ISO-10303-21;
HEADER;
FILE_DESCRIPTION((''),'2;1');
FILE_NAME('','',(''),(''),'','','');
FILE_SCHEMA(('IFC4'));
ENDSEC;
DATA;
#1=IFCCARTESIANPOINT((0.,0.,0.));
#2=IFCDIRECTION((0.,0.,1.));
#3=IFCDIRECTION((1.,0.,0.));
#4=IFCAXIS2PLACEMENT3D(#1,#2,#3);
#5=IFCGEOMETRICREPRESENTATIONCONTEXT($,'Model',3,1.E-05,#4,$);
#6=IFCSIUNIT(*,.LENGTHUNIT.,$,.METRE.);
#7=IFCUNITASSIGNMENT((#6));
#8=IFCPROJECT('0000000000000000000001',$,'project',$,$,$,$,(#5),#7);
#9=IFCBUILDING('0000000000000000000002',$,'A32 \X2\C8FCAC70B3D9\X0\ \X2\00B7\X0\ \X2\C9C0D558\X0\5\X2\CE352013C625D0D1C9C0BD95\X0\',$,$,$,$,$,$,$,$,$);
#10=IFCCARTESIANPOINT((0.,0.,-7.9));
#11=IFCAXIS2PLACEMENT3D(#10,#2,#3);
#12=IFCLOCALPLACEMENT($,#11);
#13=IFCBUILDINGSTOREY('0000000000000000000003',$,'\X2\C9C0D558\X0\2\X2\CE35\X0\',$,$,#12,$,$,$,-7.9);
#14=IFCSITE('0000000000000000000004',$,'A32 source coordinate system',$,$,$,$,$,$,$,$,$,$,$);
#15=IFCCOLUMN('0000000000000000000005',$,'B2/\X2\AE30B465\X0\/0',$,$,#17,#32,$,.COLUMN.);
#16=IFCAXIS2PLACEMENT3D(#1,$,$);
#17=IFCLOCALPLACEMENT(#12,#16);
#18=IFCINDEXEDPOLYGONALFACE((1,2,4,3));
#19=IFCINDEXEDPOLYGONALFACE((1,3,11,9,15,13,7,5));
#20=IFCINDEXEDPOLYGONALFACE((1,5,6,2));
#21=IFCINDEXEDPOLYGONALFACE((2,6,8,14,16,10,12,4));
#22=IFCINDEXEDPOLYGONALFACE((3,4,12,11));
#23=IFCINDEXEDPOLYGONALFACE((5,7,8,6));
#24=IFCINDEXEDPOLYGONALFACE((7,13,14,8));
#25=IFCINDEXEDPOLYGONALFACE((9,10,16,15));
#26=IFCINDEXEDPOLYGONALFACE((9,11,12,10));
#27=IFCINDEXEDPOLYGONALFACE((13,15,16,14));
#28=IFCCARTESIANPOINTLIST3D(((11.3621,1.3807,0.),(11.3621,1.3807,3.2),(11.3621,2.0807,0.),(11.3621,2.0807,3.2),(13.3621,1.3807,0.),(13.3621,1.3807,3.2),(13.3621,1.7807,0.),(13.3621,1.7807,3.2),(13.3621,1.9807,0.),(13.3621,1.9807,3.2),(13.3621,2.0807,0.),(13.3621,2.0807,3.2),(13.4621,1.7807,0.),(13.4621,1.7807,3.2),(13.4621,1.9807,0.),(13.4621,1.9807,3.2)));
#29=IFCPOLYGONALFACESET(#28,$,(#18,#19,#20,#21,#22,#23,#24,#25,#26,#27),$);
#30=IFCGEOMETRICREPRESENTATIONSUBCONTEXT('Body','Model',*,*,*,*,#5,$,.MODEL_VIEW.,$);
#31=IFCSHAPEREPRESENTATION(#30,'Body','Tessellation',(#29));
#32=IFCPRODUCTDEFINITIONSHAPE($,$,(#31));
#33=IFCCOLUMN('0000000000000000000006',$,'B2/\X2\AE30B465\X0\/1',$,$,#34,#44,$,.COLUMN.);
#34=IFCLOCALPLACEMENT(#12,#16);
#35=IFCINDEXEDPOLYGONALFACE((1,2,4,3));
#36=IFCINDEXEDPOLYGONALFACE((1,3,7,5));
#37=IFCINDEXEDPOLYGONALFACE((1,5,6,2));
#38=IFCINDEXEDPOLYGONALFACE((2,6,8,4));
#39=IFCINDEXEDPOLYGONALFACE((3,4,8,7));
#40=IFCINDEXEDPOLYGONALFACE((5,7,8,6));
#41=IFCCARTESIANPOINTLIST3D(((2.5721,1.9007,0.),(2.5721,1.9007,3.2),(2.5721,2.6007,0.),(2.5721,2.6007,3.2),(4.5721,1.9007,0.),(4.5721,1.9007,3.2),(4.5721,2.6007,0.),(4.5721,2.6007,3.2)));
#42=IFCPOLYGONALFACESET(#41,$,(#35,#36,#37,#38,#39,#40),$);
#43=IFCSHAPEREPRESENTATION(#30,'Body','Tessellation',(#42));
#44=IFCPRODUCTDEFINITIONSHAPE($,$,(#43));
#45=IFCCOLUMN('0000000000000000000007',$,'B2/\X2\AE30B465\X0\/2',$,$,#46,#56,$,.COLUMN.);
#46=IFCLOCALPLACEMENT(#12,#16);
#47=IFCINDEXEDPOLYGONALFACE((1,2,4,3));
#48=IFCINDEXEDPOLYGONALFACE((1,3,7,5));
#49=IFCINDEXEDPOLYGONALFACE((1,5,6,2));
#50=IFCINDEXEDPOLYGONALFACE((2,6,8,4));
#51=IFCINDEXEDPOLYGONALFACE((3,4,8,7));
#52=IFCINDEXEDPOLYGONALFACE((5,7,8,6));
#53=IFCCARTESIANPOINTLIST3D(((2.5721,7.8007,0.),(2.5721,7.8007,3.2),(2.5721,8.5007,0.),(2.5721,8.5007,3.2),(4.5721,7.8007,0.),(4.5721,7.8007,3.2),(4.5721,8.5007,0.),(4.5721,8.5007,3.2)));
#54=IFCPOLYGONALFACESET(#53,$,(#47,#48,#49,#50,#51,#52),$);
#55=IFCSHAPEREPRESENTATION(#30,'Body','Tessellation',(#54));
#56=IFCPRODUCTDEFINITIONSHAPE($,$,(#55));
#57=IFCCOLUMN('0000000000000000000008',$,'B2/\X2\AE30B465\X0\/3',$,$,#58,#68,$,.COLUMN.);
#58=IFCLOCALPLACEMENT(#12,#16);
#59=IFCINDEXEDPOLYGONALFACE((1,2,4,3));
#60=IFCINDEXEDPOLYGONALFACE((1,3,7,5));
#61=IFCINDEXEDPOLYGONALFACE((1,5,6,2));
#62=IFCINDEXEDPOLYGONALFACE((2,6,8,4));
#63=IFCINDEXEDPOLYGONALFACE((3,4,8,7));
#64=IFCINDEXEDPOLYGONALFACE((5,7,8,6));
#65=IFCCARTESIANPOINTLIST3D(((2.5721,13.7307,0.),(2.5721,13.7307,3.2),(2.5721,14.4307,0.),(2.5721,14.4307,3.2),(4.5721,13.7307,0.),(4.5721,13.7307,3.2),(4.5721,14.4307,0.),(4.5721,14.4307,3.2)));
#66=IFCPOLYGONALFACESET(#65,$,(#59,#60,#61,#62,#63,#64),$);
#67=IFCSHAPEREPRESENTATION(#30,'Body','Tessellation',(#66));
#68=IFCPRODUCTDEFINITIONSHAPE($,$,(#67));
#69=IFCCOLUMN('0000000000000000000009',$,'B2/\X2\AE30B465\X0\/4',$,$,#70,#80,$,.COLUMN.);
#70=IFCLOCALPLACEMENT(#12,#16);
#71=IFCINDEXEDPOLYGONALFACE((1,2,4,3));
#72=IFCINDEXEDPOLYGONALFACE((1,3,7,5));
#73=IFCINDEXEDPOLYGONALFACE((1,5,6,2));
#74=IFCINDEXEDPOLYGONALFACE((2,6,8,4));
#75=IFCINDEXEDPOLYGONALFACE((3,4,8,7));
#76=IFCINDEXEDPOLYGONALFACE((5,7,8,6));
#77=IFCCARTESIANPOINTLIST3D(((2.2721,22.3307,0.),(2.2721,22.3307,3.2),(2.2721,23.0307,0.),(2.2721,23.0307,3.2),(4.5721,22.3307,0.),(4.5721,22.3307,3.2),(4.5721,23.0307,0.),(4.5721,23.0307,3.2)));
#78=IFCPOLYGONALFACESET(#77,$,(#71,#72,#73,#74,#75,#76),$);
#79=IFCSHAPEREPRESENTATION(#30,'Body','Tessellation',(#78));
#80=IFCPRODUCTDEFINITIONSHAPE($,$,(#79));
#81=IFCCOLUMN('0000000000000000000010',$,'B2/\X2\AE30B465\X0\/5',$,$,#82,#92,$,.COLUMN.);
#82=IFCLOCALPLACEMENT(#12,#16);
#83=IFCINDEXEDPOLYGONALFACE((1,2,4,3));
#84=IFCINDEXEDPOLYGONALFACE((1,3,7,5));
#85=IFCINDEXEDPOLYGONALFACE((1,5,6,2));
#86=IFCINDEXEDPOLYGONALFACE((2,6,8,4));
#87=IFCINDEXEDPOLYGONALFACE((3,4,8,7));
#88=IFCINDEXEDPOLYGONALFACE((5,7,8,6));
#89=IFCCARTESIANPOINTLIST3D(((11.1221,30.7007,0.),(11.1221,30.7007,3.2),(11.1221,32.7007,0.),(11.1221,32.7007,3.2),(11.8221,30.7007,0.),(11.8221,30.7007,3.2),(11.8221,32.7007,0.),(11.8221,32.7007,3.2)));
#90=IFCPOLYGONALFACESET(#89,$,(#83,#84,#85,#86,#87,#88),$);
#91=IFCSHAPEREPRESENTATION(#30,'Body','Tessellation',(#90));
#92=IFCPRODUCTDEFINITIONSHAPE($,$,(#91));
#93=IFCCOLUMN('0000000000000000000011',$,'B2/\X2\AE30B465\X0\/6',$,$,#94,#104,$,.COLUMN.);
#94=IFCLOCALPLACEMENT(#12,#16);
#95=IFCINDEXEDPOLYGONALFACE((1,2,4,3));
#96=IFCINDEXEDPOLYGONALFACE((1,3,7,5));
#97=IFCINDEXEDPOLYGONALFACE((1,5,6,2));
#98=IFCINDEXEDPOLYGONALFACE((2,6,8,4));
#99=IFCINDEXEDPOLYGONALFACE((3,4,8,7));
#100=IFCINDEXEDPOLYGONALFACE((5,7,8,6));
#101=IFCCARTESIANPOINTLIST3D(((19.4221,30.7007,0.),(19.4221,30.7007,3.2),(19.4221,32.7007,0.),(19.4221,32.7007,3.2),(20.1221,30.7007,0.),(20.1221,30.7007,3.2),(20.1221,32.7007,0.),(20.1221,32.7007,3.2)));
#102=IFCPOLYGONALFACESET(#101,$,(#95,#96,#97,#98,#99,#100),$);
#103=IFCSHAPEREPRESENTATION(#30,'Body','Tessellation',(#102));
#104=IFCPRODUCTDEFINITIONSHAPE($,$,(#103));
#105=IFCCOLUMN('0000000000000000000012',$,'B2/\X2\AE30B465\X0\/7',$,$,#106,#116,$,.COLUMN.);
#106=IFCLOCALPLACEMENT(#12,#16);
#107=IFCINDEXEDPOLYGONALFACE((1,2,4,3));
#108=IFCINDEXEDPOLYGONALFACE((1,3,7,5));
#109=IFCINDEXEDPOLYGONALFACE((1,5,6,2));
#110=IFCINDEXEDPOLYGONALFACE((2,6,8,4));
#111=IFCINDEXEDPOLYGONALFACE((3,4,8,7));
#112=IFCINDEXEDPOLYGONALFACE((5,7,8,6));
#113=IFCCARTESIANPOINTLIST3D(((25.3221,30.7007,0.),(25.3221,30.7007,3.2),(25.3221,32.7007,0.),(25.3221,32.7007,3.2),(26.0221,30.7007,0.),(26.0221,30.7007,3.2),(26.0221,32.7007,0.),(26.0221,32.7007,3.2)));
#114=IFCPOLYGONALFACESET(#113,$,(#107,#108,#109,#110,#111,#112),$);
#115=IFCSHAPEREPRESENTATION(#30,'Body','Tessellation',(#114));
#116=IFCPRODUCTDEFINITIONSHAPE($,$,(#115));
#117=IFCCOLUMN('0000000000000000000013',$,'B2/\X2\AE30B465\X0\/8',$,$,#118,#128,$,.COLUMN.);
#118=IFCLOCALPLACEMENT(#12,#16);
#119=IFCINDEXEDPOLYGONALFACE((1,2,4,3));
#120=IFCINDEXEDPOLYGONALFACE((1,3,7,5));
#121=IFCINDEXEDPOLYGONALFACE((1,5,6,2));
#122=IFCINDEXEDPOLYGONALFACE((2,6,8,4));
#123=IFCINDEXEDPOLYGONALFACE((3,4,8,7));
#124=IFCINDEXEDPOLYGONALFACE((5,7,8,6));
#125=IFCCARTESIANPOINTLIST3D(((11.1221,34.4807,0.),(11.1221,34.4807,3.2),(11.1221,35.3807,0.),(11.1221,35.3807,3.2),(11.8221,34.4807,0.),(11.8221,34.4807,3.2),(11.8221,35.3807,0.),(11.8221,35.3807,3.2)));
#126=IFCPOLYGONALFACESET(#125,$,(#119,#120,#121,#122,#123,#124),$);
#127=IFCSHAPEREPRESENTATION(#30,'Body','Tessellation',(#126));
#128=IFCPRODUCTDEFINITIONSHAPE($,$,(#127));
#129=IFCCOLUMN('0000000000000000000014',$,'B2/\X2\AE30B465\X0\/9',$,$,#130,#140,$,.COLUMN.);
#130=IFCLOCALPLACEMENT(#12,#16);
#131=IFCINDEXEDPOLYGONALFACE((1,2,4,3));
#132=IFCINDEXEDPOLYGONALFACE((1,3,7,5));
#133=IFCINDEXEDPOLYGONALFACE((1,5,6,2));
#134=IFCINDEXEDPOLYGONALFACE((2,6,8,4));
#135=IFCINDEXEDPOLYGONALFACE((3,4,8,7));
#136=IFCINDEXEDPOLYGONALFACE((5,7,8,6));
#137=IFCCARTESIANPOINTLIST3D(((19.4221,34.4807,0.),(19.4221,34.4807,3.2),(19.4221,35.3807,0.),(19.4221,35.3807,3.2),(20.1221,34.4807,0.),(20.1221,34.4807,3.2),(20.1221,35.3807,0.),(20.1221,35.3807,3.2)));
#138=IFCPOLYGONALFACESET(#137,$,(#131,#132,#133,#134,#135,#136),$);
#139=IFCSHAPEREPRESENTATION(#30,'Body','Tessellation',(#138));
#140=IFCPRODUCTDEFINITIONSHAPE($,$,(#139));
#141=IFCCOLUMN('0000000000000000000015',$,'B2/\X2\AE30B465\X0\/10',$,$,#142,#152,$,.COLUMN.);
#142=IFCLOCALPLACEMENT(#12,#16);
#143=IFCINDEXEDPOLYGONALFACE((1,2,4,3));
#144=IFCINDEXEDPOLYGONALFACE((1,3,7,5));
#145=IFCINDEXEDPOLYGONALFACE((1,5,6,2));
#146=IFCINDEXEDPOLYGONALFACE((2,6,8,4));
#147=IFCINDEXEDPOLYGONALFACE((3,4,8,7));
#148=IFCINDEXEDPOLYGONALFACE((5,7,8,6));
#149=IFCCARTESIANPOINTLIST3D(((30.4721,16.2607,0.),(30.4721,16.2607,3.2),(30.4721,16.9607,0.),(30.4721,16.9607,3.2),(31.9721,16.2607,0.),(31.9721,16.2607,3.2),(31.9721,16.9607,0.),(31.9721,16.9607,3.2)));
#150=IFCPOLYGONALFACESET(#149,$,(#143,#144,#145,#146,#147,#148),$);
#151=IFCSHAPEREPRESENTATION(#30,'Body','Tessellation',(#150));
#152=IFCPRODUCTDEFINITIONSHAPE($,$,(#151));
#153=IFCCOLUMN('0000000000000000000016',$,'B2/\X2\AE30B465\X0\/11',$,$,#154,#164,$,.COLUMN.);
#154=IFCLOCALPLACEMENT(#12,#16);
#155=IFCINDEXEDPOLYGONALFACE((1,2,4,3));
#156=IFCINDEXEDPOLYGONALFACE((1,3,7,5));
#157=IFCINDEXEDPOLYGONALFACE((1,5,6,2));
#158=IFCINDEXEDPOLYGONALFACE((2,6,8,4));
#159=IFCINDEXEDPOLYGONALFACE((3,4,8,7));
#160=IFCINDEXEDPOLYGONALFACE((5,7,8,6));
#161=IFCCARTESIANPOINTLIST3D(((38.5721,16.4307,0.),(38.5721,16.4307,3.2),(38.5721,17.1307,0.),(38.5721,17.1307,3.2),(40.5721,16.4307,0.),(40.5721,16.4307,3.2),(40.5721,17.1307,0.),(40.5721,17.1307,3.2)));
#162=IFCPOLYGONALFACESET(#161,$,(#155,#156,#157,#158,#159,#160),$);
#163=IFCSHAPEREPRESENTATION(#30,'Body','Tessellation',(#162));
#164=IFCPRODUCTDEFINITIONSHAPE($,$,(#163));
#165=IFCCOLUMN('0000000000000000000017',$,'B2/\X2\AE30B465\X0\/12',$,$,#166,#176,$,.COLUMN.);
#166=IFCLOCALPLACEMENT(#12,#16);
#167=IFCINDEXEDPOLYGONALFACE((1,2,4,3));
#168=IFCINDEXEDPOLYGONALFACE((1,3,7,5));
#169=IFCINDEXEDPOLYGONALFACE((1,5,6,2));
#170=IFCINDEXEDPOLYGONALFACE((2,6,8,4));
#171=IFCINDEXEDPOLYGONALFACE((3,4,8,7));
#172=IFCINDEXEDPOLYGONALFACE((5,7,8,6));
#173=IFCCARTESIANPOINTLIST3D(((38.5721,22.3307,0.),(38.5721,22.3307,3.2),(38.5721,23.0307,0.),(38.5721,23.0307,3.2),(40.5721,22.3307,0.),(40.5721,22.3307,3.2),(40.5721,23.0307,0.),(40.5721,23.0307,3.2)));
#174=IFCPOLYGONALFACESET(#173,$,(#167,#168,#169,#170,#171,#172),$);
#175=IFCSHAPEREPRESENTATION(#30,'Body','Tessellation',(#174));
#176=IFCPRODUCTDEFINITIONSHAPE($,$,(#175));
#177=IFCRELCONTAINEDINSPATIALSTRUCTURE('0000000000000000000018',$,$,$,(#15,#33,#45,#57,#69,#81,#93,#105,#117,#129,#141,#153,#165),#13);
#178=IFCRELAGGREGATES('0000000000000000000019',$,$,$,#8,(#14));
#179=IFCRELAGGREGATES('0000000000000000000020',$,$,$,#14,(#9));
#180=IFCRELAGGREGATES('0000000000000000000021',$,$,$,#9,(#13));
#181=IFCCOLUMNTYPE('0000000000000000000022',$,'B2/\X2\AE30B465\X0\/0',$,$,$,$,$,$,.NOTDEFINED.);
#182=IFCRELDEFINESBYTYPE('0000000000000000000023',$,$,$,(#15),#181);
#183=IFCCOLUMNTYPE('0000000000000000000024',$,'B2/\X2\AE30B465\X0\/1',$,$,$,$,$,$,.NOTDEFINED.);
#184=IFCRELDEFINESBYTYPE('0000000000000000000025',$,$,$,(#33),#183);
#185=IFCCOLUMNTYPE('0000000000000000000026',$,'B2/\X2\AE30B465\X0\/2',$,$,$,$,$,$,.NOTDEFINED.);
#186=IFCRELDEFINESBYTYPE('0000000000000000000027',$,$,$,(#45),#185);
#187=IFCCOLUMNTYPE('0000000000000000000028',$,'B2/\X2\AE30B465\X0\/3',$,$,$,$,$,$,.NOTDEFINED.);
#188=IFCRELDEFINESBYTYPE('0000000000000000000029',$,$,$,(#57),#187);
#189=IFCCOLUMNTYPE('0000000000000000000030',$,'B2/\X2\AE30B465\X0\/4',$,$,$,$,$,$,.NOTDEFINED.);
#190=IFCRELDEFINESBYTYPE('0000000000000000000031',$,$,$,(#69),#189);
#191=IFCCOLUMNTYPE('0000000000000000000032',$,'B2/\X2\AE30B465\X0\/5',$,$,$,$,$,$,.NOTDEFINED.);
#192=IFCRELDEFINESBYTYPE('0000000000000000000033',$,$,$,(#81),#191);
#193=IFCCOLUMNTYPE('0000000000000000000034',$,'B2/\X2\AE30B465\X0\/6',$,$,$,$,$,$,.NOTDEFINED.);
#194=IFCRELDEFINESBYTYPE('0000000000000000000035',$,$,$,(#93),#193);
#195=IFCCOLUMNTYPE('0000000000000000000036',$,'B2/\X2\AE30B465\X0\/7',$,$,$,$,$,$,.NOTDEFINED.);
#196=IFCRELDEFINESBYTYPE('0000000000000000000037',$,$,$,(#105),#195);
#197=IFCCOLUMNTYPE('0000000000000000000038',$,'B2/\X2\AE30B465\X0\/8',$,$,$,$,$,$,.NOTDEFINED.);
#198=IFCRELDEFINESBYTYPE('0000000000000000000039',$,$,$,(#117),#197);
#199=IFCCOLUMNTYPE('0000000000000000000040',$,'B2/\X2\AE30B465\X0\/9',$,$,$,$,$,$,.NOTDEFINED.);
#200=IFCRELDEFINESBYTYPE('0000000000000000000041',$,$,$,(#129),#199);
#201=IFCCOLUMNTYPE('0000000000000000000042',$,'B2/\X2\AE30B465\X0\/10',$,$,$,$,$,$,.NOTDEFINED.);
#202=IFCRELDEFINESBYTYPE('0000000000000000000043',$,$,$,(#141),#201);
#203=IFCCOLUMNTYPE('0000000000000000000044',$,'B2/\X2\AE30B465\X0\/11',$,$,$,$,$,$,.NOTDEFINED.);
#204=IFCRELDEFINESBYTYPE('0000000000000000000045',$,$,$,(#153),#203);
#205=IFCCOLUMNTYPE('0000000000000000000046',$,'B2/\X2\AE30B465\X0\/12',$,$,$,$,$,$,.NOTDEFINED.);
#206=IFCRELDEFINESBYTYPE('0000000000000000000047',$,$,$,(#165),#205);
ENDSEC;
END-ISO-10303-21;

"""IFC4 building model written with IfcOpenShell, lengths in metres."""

from ifc_helpers import new_model, si_unit, frame, origin, origin_with_axes, place, context, subcontext, project, spatial, polyline, outline, extrude, source, transform, mapped, type_object, type_shapes, element, save


model = new_model("IFC4")

# Units and contexts
model_context = context("Model", 3, precision=1e-05, world=origin_with_axes())
body_context = subcontext(model_context, "Body", "Model", "MODEL_VIEW")
ifc_project = project(units=[si_unit("LENGTHUNIT", "METRE")], contexts=[model_context])

# Site, building, storey
site = spatial("IfcSite", under=ifc_project, Name="A32 source coordinate system")
building = spatial("IfcBuilding", under=site, Name="A32 주거동 · 지하5층–옥탑지붕")
storey_placement = place(None, frame((0.0, 0.0, -7.9), z_axis=(0.0, 0.0, 1.0), x_axis=(1.0, 0.0, 0.0)))
storey = spatial("IfcBuildingStorey", under=building, at=storey_placement, Name="지하2층", Elevation=-7.9)

# Columns
column_type_1 = type_object("IfcColumnType", Name="B2/기둥/0", PredefinedType="NOTDEFINED")
shared_shape_1 = source(origin(), body_context, "Body", "SweptSolid", [
    extrude(outline(polyline([(11.3621, 1.3807), (11.3621, 2.0807), (13.3621, 2.0807), (13.3621, 1.9807), (13.4621, 1.9807), (13.4621, 1.7807), (13.3621, 1.7807), (13.3621, 1.3807), (11.3621, 1.3807)])), origin(), (0.0, 0.0, 1.0), 3.2),
])
type_shapes(column_type_1, [shared_shape_1])
column_1_placement = place(storey_placement, origin_with_axes())
element("IfcColumn", 1, at=column_1_placement, inside=storey, type_object=column_type_1, Name="B2/기둥/0", PredefinedType="COLUMN", context=body_context, shape_type="MappedRepresentation", body=[
    mapped(shared_shape_1, transform((0.0, 0.0, 0.0), scale=1.0)),
])
column_type_2 = type_object("IfcColumnType", Name="B2/기둥/1", PredefinedType="NOTDEFINED")
shared_shape_2 = source(origin(), body_context, "Body", "SweptSolid", [
    extrude(outline(polyline([(4.5721, 1.9007), (2.5721, 1.9007), (2.5721, 2.6007), (4.5721, 2.6007), (4.5721, 1.9007)])), origin(), (0.0, 0.0, 1.0), 3.2),
])
type_shapes(column_type_2, [shared_shape_2])
column_2_placement = place(storey_placement, origin_with_axes())
element("IfcColumn", 2, at=column_2_placement, inside=storey, type_object=column_type_2, Name="B2/기둥/1", PredefinedType="COLUMN", context=body_context, shape_type="MappedRepresentation", body=[
    mapped(shared_shape_2, transform((0.0, 0.0, 0.0), scale=1.0)),
])
column_type_3 = type_object("IfcColumnType", Name="B2/기둥/2", PredefinedType="NOTDEFINED")
shared_shape_3 = source(origin(), body_context, "Body", "SweptSolid", [
    extrude(outline(polyline([(4.5721, 7.8007), (2.5721, 7.8007), (2.5721, 8.5007), (4.5721, 8.5007), (4.5721, 7.8007)])), origin(), (0.0, 0.0, 1.0), 3.2),
])
type_shapes(column_type_3, [shared_shape_3])
column_3_placement = place(storey_placement, origin_with_axes())
element("IfcColumn", 3, at=column_3_placement, inside=storey, type_object=column_type_3, Name="B2/기둥/2", PredefinedType="COLUMN", context=body_context, shape_type="MappedRepresentation", body=[
    mapped(shared_shape_3, transform((0.0, 0.0, 0.0), scale=1.0)),
])
column_type_4 = type_object("IfcColumnType", Name="B2/기둥/3", PredefinedType="NOTDEFINED")
shared_shape_4 = source(origin(), body_context, "Body", "SweptSolid", [
    extrude(outline(polyline([(4.5721, 14.4307), (4.5721, 13.7307), (2.5721, 13.7307), (2.5721, 14.4307), (4.5721, 14.4307)])), origin(), (0.0, 0.0, 1.0), 3.2),
])
type_shapes(column_type_4, [shared_shape_4])
column_4_placement = place(storey_placement, origin_with_axes())
element("IfcColumn", 4, at=column_4_placement, inside=storey, type_object=column_type_4, Name="B2/기둥/3", PredefinedType="COLUMN", context=body_context, shape_type="MappedRepresentation", body=[
    mapped(shared_shape_4, transform((0.0, 0.0, 0.0), scale=1.0)),
])
column_type_5 = type_object("IfcColumnType", Name="B2/기둥/4", PredefinedType="NOTDEFINED")
shared_shape_5 = source(origin(), body_context, "Body", "SweptSolid", [
    extrude(outline(polyline([(2.2721, 23.0307), (4.5721, 23.0307), (4.5721, 22.3307), (2.2721, 22.3307), (2.2721, 23.0307)])), origin(), (0.0, 0.0, 1.0), 3.2),
])
type_shapes(column_type_5, [shared_shape_5])
column_5_placement = place(storey_placement, origin_with_axes())
element("IfcColumn", 5, at=column_5_placement, inside=storey, type_object=column_type_5, Name="B2/기둥/4", PredefinedType="COLUMN", context=body_context, shape_type="MappedRepresentation", body=[
    mapped(shared_shape_5, transform((0.0, 0.0, 0.0), scale=1.0)),
])
column_type_6 = type_object("IfcColumnType", Name="B2/기둥/5", PredefinedType="NOTDEFINED")
shared_shape_6 = source(origin(), body_context, "Body", "SweptSolid", [
    extrude(outline(polyline([(11.8221, 30.7007), (11.1221, 30.7007), (11.1221, 32.7007), (11.8221, 32.7007), (11.8221, 30.7007)])), origin(), (0.0, 0.0, 1.0), 3.2),
])
type_shapes(column_type_6, [shared_shape_6])
column_6_placement = place(storey_placement, origin_with_axes())
element("IfcColumn", 6, at=column_6_placement, inside=storey, type_object=column_type_6, Name="B2/기둥/5", PredefinedType="COLUMN", context=body_context, shape_type="MappedRepresentation", body=[
    mapped(shared_shape_6, transform((0.0, 0.0, 0.0), scale=1.0)),
])
column_type_7 = type_object("IfcColumnType", Name="B2/기둥/6", PredefinedType="NOTDEFINED")
shared_shape_7 = source(origin(), body_context, "Body", "SweptSolid", [
    extrude(outline(polyline([(20.1221, 30.7007), (19.4221, 30.7007), (19.4221, 32.7007), (20.1221, 32.7007), (20.1221, 30.7007)])), origin(), (0.0, 0.0, 1.0), 3.2),
])
type_shapes(column_type_7, [shared_shape_7])
column_7_placement = place(storey_placement, origin_with_axes())
element("IfcColumn", 7, at=column_7_placement, inside=storey, type_object=column_type_7, Name="B2/기둥/6", PredefinedType="COLUMN", context=body_context, shape_type="MappedRepresentation", body=[
    mapped(shared_shape_7, transform((0.0, 0.0, 0.0), scale=1.0)),
])
column_type_8 = type_object("IfcColumnType", Name="B2/기둥/7", PredefinedType="NOTDEFINED")
shared_shape_8 = source(origin(), body_context, "Body", "SweptSolid", [
    extrude(outline(polyline([(26.0221, 30.7007), (25.3221, 30.7007), (25.3221, 32.7007), (26.0221, 32.7007), (26.0221, 30.7007)])), origin(), (0.0, 0.0, 1.0), 3.2),
])
type_shapes(column_type_8, [shared_shape_8])
column_8_placement = place(storey_placement, origin_with_axes())
element("IfcColumn", 8, at=column_8_placement, inside=storey, type_object=column_type_8, Name="B2/기둥/7", PredefinedType="COLUMN", context=body_context, shape_type="MappedRepresentation", body=[
    mapped(shared_shape_8, transform((0.0, 0.0, 0.0), scale=1.0)),
])
column_type_9 = type_object("IfcColumnType", Name="B2/기둥/8", PredefinedType="NOTDEFINED")
shared_shape_9 = source(origin(), body_context, "Body", "SweptSolid", [
    extrude(outline(polyline([(11.1221, 34.4807), (11.1221, 35.3807), (11.8221, 35.3807), (11.8221, 34.4807), (11.1221, 34.4807)])), origin(), (0.0, 0.0, 1.0), 3.2),
])
type_shapes(column_type_9, [shared_shape_9])
column_9_placement = place(storey_placement, origin_with_axes())
element("IfcColumn", 9, at=column_9_placement, inside=storey, type_object=column_type_9, Name="B2/기둥/8", PredefinedType="COLUMN", context=body_context, shape_type="MappedRepresentation", body=[
    mapped(shared_shape_9, transform((0.0, 0.0, 0.0), scale=1.0)),
])
column_type_10 = type_object("IfcColumnType", Name="B2/기둥/9", PredefinedType="NOTDEFINED")
shared_shape_10 = source(origin(), body_context, "Body", "SweptSolid", [
    extrude(outline(polyline([(20.1221, 35.3807), (20.1221, 34.4807), (19.4221, 34.4807), (19.4221, 35.3807), (20.1221, 35.3807)])), origin(), (0.0, 0.0, 1.0), 3.2),
])
type_shapes(column_type_10, [shared_shape_10])
column_10_placement = place(storey_placement, origin_with_axes())
element("IfcColumn", 10, at=column_10_placement, inside=storey, type_object=column_type_10, Name="B2/기둥/9", PredefinedType="COLUMN", context=body_context, shape_type="MappedRepresentation", body=[
    mapped(shared_shape_10, transform((0.0, 0.0, 0.0), scale=1.0)),
])
column_type_11 = type_object("IfcColumnType", Name="B2/기둥/10", PredefinedType="NOTDEFINED")
shared_shape_11 = source(origin(), body_context, "Body", "SweptSolid", [
    extrude(outline(polyline([(30.4721, 16.9607), (31.9721, 16.9607), (31.9721, 16.2607), (30.4721, 16.2607), (30.4721, 16.9607)])), origin(), (0.0, 0.0, 1.0), 3.2),
])
type_shapes(column_type_11, [shared_shape_11])
column_11_placement = place(storey_placement, origin_with_axes())
element("IfcColumn", 11, at=column_11_placement, inside=storey, type_object=column_type_11, Name="B2/기둥/10", PredefinedType="COLUMN", context=body_context, shape_type="MappedRepresentation", body=[
    mapped(shared_shape_11, transform((0.0, 0.0, 0.0), scale=1.0)),
])
column_type_12 = type_object("IfcColumnType", Name="B2/기둥/11", PredefinedType="NOTDEFINED")
shared_shape_12 = source(origin(), body_context, "Body", "SweptSolid", [
    extrude(outline(polyline([(40.5721, 16.4307), (38.5721, 16.4307), (38.5721, 17.1307), (40.5721, 17.1307), (40.5721, 16.4307)])), origin(), (0.0, 0.0, 1.0), 3.2),
])
type_shapes(column_type_12, [shared_shape_12])
column_12_placement = place(storey_placement, origin_with_axes())
element("IfcColumn", 12, at=column_12_placement, inside=storey, type_object=column_type_12, Name="B2/기둥/11", PredefinedType="COLUMN", context=body_context, shape_type="MappedRepresentation", body=[
    mapped(shared_shape_12, transform((0.0, 0.0, 0.0), scale=1.0)),
])
column_type_13 = type_object("IfcColumnType", Name="B2/기둥/12", PredefinedType="NOTDEFINED")
shared_shape_13 = source(origin(), body_context, "Body", "SweptSolid", [
    extrude(outline(polyline([(40.5721, 22.3307), (38.5721, 22.3307), (38.5721, 23.0307), (40.5721, 23.0307), (40.5721, 22.3307)])), origin(), (0.0, 0.0, 1.0), 3.2),
])
type_shapes(column_type_13, [shared_shape_13])
column_13_placement = place(storey_placement, origin_with_axes())
element("IfcColumn", 13, at=column_13_placement, inside=storey, type_object=column_type_13, Name="B2/기둥/12", PredefinedType="COLUMN", context=body_context, shape_type="MappedRepresentation", body=[
    mapped(shared_shape_13, transform((0.0, 0.0, 0.0), scale=1.0)),
])

save(model, "model.ifc")
